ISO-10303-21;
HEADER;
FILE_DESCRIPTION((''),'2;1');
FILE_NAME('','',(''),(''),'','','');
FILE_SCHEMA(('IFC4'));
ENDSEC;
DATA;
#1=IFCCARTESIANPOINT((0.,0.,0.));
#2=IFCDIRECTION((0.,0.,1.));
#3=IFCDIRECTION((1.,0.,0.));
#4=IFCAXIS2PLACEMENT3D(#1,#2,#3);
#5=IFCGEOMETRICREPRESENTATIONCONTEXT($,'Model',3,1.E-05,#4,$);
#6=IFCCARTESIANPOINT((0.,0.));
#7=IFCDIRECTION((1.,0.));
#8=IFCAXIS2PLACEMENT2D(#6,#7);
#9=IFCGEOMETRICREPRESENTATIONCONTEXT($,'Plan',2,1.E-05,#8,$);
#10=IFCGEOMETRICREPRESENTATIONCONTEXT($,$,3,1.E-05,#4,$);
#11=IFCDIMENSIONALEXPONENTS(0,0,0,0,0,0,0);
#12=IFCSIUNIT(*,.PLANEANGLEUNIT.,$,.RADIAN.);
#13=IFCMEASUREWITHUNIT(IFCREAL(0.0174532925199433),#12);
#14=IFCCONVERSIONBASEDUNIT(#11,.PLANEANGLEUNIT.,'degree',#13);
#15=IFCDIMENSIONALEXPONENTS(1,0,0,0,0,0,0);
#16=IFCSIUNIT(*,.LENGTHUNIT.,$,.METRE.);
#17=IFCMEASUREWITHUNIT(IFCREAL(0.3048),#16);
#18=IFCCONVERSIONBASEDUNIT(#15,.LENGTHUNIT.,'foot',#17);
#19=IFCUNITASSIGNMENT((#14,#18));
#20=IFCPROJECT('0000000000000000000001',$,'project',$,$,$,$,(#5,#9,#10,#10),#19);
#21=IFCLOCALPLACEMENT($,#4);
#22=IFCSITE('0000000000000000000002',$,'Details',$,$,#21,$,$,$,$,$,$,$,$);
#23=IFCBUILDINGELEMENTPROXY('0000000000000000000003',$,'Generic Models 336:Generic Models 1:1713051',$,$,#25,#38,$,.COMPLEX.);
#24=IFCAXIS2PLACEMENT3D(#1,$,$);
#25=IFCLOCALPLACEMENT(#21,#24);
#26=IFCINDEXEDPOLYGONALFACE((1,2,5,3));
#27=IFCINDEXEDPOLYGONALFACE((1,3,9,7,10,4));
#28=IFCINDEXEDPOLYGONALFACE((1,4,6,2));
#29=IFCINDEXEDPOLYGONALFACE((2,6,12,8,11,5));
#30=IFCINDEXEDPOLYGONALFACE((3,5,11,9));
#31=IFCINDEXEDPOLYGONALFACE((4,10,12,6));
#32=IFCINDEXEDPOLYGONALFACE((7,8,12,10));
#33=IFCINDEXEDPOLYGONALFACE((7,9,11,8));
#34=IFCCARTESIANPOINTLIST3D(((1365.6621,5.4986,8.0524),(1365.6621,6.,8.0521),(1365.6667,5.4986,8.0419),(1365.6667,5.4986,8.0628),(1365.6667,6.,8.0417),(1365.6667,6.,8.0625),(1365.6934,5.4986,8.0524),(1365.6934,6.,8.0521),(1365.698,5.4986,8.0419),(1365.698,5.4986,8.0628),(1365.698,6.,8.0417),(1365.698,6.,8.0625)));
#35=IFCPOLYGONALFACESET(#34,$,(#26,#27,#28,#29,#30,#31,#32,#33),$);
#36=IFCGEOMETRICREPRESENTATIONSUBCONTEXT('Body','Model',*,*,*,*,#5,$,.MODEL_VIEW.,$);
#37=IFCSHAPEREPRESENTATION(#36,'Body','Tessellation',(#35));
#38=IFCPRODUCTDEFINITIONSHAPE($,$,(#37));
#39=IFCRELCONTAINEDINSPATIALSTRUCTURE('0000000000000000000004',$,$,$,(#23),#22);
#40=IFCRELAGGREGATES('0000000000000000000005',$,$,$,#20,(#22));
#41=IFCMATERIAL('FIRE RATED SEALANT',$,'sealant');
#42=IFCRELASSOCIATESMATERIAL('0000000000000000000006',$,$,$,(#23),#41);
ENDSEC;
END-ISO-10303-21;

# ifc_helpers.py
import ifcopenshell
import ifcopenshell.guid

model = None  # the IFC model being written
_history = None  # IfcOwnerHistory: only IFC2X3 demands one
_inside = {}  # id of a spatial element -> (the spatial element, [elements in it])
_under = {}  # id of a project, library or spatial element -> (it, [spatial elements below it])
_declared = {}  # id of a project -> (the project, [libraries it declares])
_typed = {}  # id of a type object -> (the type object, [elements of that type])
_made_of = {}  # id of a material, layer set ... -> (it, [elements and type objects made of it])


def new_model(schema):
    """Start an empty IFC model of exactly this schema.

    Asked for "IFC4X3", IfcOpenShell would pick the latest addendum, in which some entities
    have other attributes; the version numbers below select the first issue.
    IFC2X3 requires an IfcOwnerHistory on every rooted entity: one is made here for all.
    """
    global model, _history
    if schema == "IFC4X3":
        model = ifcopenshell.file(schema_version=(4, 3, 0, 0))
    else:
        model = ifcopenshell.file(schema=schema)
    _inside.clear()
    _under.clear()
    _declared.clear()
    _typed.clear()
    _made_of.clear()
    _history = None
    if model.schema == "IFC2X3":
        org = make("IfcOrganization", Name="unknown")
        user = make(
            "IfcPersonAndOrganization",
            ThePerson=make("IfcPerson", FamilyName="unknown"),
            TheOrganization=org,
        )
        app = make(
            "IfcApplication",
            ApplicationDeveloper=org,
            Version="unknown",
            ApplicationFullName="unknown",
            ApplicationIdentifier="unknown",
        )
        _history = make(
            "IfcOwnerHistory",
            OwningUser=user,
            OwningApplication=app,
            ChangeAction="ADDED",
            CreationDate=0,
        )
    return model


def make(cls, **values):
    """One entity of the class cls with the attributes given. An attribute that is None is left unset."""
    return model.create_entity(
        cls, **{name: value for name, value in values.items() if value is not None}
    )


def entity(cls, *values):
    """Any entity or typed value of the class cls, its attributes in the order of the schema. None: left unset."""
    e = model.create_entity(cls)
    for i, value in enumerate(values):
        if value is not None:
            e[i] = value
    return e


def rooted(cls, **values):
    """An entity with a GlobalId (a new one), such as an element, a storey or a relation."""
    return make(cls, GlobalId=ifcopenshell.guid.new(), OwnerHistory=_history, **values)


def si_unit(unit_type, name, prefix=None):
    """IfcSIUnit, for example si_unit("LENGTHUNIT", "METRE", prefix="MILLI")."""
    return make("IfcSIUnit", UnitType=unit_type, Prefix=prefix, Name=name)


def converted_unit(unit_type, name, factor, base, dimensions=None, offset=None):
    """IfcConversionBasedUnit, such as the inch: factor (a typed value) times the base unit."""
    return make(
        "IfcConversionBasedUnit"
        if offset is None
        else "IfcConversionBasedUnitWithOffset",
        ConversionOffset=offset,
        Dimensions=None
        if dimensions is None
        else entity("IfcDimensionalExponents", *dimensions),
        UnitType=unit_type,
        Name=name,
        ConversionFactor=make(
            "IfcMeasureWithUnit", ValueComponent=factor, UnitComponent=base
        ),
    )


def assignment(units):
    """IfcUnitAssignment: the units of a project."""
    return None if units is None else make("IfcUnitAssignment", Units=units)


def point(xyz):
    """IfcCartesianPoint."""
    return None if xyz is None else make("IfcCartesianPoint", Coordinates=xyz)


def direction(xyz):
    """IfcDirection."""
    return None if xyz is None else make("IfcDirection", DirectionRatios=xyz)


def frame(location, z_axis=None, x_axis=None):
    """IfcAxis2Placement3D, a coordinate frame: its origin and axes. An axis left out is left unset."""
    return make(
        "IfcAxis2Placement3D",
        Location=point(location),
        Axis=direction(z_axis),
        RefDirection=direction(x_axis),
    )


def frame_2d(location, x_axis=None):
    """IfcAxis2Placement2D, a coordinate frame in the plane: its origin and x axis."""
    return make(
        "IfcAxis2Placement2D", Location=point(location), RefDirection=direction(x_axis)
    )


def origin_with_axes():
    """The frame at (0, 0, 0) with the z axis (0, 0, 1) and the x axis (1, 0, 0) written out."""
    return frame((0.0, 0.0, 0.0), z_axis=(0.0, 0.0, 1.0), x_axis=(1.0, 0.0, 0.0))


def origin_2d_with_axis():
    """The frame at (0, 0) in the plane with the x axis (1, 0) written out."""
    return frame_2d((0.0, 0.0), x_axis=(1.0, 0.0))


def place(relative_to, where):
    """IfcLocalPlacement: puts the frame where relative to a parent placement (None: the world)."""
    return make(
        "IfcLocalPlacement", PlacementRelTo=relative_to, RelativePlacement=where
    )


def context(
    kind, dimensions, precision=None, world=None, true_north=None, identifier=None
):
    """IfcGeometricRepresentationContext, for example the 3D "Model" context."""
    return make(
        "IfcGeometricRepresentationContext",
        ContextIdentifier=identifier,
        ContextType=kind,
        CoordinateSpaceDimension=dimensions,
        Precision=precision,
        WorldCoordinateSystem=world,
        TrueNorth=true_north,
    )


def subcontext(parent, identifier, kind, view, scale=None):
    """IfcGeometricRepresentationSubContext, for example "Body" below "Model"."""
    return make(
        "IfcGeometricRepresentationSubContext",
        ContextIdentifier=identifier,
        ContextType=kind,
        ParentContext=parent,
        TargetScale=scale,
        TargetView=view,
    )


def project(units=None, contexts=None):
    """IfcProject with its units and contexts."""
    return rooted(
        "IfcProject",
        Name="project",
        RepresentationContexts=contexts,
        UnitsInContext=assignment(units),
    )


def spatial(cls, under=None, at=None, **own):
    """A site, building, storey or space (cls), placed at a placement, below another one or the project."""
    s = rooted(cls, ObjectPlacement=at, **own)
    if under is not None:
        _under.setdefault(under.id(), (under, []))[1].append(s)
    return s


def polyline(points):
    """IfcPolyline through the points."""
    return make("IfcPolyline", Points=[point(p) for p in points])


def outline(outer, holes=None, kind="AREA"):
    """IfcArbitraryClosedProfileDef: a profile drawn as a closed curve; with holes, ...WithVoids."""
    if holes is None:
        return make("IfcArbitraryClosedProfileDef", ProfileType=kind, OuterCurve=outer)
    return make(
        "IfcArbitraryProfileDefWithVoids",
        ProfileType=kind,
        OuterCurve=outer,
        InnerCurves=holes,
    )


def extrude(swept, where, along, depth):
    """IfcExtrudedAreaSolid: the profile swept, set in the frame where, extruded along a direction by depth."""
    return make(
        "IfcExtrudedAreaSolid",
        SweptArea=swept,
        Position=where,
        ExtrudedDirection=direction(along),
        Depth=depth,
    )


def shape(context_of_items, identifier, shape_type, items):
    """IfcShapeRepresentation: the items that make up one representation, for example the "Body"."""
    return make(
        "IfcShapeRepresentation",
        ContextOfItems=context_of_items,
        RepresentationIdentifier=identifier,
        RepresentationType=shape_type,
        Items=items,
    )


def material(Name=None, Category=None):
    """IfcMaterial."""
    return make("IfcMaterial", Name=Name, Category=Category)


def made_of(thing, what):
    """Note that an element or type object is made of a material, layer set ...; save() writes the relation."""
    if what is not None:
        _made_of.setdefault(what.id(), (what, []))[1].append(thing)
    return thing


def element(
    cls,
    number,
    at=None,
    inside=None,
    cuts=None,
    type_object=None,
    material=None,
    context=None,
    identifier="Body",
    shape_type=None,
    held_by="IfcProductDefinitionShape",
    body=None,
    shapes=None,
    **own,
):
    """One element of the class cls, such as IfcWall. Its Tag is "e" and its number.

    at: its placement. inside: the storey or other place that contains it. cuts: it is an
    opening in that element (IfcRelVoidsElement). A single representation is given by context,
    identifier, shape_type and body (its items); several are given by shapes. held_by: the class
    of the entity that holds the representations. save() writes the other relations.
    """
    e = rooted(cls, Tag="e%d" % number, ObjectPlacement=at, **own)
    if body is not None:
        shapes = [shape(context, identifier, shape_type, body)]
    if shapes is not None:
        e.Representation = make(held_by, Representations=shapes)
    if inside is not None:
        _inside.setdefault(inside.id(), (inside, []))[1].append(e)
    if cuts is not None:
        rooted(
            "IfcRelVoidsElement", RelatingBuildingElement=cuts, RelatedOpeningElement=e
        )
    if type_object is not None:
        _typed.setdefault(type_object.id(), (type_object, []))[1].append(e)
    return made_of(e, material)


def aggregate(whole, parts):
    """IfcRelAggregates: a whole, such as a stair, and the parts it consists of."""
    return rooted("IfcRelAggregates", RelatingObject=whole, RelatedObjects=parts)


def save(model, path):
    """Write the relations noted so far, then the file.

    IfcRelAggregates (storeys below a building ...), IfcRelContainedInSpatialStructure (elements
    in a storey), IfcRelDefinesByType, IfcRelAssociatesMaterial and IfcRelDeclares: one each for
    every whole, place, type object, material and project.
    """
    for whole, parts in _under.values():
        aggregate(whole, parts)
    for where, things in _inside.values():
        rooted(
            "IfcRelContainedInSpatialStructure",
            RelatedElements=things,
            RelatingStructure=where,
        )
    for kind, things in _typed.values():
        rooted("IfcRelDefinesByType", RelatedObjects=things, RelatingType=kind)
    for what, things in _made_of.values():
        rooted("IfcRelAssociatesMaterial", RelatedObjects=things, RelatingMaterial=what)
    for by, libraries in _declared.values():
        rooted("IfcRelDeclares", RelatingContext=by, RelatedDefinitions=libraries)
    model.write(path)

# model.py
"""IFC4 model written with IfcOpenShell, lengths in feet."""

from ifc_helpers import new_model, entity, si_unit, converted_unit, frame, origin_with_axes, origin_2d_with_axis, place, context, subcontext, project, spatial, polyline, outline, extrude, material, element, save


model = new_model("IFC4")

# Units and contexts
model_context = context("Model", 3, precision=1e-05, world=origin_with_axes())
plan_context = context("Plan", 2, precision=1e-05, world=origin_2d_with_axis())
context_of_model = context(None, 3, precision=1e-05, world=origin_with_axes())
body_context = subcontext(model_context, "Body", "Model", "MODEL_VIEW")
ifc_project = project(units=[converted_unit("PLANEANGLEUNIT", "degree", entity("IfcReal", 0.0174532925199433), si_unit("PLANEANGLEUNIT", "RADIAN"), dimensions=[0, 0, 0, 0, 0, 0, 0]), converted_unit("LENGTHUNIT", "foot", entity("IfcReal", 0.3048), si_unit("LENGTHUNIT", "METRE"), dimensions=[1, 0, 0, 0, 0, 0, 0])], contexts=[model_context, plan_context, context_of_model, context_of_model])

# Site
site_placement = place(None, origin_with_axes())
site = spatial("IfcSite", under=ifc_project, at=site_placement, Name="Details")

# Building element proxy
ifc_material_1 = material(Name="FIRE RATED SEALANT", Category="sealant")
proxy_1_placement = place(site_placement, frame((1365.6622, 6.0, 8.0417), z_axis=(0.0, -1.0, 0.0), x_axis=(0.0, 0.0, 1.0)))
element("IfcBuildingElementProxy", 1, at=proxy_1_placement, inside=site, material=ifc_material_1, Name="Generic Models 336:Generic Models 1:1713051", PredefinedType="COMPLEX", context=body_context, shape_type="SweptSolid", body=[
    extrude(outline(polyline([(0.0201, 0.0), (0.0107, 0.0065), (0.0093, 0.0178), (-0.0175, 0.0016), (-0.016, -0.0097), (-0.0066, -0.0162), (0.0201, 0.0)])), frame((0.0104, -0.0186, 0.0), z_axis=(0.0, 0.0, -1.0), x_axis=(0.51911, -0.854707, 0.0)), (0.000294, -0.000474, -1.0), 0.5014),
])

save(model, "model.ifc")
